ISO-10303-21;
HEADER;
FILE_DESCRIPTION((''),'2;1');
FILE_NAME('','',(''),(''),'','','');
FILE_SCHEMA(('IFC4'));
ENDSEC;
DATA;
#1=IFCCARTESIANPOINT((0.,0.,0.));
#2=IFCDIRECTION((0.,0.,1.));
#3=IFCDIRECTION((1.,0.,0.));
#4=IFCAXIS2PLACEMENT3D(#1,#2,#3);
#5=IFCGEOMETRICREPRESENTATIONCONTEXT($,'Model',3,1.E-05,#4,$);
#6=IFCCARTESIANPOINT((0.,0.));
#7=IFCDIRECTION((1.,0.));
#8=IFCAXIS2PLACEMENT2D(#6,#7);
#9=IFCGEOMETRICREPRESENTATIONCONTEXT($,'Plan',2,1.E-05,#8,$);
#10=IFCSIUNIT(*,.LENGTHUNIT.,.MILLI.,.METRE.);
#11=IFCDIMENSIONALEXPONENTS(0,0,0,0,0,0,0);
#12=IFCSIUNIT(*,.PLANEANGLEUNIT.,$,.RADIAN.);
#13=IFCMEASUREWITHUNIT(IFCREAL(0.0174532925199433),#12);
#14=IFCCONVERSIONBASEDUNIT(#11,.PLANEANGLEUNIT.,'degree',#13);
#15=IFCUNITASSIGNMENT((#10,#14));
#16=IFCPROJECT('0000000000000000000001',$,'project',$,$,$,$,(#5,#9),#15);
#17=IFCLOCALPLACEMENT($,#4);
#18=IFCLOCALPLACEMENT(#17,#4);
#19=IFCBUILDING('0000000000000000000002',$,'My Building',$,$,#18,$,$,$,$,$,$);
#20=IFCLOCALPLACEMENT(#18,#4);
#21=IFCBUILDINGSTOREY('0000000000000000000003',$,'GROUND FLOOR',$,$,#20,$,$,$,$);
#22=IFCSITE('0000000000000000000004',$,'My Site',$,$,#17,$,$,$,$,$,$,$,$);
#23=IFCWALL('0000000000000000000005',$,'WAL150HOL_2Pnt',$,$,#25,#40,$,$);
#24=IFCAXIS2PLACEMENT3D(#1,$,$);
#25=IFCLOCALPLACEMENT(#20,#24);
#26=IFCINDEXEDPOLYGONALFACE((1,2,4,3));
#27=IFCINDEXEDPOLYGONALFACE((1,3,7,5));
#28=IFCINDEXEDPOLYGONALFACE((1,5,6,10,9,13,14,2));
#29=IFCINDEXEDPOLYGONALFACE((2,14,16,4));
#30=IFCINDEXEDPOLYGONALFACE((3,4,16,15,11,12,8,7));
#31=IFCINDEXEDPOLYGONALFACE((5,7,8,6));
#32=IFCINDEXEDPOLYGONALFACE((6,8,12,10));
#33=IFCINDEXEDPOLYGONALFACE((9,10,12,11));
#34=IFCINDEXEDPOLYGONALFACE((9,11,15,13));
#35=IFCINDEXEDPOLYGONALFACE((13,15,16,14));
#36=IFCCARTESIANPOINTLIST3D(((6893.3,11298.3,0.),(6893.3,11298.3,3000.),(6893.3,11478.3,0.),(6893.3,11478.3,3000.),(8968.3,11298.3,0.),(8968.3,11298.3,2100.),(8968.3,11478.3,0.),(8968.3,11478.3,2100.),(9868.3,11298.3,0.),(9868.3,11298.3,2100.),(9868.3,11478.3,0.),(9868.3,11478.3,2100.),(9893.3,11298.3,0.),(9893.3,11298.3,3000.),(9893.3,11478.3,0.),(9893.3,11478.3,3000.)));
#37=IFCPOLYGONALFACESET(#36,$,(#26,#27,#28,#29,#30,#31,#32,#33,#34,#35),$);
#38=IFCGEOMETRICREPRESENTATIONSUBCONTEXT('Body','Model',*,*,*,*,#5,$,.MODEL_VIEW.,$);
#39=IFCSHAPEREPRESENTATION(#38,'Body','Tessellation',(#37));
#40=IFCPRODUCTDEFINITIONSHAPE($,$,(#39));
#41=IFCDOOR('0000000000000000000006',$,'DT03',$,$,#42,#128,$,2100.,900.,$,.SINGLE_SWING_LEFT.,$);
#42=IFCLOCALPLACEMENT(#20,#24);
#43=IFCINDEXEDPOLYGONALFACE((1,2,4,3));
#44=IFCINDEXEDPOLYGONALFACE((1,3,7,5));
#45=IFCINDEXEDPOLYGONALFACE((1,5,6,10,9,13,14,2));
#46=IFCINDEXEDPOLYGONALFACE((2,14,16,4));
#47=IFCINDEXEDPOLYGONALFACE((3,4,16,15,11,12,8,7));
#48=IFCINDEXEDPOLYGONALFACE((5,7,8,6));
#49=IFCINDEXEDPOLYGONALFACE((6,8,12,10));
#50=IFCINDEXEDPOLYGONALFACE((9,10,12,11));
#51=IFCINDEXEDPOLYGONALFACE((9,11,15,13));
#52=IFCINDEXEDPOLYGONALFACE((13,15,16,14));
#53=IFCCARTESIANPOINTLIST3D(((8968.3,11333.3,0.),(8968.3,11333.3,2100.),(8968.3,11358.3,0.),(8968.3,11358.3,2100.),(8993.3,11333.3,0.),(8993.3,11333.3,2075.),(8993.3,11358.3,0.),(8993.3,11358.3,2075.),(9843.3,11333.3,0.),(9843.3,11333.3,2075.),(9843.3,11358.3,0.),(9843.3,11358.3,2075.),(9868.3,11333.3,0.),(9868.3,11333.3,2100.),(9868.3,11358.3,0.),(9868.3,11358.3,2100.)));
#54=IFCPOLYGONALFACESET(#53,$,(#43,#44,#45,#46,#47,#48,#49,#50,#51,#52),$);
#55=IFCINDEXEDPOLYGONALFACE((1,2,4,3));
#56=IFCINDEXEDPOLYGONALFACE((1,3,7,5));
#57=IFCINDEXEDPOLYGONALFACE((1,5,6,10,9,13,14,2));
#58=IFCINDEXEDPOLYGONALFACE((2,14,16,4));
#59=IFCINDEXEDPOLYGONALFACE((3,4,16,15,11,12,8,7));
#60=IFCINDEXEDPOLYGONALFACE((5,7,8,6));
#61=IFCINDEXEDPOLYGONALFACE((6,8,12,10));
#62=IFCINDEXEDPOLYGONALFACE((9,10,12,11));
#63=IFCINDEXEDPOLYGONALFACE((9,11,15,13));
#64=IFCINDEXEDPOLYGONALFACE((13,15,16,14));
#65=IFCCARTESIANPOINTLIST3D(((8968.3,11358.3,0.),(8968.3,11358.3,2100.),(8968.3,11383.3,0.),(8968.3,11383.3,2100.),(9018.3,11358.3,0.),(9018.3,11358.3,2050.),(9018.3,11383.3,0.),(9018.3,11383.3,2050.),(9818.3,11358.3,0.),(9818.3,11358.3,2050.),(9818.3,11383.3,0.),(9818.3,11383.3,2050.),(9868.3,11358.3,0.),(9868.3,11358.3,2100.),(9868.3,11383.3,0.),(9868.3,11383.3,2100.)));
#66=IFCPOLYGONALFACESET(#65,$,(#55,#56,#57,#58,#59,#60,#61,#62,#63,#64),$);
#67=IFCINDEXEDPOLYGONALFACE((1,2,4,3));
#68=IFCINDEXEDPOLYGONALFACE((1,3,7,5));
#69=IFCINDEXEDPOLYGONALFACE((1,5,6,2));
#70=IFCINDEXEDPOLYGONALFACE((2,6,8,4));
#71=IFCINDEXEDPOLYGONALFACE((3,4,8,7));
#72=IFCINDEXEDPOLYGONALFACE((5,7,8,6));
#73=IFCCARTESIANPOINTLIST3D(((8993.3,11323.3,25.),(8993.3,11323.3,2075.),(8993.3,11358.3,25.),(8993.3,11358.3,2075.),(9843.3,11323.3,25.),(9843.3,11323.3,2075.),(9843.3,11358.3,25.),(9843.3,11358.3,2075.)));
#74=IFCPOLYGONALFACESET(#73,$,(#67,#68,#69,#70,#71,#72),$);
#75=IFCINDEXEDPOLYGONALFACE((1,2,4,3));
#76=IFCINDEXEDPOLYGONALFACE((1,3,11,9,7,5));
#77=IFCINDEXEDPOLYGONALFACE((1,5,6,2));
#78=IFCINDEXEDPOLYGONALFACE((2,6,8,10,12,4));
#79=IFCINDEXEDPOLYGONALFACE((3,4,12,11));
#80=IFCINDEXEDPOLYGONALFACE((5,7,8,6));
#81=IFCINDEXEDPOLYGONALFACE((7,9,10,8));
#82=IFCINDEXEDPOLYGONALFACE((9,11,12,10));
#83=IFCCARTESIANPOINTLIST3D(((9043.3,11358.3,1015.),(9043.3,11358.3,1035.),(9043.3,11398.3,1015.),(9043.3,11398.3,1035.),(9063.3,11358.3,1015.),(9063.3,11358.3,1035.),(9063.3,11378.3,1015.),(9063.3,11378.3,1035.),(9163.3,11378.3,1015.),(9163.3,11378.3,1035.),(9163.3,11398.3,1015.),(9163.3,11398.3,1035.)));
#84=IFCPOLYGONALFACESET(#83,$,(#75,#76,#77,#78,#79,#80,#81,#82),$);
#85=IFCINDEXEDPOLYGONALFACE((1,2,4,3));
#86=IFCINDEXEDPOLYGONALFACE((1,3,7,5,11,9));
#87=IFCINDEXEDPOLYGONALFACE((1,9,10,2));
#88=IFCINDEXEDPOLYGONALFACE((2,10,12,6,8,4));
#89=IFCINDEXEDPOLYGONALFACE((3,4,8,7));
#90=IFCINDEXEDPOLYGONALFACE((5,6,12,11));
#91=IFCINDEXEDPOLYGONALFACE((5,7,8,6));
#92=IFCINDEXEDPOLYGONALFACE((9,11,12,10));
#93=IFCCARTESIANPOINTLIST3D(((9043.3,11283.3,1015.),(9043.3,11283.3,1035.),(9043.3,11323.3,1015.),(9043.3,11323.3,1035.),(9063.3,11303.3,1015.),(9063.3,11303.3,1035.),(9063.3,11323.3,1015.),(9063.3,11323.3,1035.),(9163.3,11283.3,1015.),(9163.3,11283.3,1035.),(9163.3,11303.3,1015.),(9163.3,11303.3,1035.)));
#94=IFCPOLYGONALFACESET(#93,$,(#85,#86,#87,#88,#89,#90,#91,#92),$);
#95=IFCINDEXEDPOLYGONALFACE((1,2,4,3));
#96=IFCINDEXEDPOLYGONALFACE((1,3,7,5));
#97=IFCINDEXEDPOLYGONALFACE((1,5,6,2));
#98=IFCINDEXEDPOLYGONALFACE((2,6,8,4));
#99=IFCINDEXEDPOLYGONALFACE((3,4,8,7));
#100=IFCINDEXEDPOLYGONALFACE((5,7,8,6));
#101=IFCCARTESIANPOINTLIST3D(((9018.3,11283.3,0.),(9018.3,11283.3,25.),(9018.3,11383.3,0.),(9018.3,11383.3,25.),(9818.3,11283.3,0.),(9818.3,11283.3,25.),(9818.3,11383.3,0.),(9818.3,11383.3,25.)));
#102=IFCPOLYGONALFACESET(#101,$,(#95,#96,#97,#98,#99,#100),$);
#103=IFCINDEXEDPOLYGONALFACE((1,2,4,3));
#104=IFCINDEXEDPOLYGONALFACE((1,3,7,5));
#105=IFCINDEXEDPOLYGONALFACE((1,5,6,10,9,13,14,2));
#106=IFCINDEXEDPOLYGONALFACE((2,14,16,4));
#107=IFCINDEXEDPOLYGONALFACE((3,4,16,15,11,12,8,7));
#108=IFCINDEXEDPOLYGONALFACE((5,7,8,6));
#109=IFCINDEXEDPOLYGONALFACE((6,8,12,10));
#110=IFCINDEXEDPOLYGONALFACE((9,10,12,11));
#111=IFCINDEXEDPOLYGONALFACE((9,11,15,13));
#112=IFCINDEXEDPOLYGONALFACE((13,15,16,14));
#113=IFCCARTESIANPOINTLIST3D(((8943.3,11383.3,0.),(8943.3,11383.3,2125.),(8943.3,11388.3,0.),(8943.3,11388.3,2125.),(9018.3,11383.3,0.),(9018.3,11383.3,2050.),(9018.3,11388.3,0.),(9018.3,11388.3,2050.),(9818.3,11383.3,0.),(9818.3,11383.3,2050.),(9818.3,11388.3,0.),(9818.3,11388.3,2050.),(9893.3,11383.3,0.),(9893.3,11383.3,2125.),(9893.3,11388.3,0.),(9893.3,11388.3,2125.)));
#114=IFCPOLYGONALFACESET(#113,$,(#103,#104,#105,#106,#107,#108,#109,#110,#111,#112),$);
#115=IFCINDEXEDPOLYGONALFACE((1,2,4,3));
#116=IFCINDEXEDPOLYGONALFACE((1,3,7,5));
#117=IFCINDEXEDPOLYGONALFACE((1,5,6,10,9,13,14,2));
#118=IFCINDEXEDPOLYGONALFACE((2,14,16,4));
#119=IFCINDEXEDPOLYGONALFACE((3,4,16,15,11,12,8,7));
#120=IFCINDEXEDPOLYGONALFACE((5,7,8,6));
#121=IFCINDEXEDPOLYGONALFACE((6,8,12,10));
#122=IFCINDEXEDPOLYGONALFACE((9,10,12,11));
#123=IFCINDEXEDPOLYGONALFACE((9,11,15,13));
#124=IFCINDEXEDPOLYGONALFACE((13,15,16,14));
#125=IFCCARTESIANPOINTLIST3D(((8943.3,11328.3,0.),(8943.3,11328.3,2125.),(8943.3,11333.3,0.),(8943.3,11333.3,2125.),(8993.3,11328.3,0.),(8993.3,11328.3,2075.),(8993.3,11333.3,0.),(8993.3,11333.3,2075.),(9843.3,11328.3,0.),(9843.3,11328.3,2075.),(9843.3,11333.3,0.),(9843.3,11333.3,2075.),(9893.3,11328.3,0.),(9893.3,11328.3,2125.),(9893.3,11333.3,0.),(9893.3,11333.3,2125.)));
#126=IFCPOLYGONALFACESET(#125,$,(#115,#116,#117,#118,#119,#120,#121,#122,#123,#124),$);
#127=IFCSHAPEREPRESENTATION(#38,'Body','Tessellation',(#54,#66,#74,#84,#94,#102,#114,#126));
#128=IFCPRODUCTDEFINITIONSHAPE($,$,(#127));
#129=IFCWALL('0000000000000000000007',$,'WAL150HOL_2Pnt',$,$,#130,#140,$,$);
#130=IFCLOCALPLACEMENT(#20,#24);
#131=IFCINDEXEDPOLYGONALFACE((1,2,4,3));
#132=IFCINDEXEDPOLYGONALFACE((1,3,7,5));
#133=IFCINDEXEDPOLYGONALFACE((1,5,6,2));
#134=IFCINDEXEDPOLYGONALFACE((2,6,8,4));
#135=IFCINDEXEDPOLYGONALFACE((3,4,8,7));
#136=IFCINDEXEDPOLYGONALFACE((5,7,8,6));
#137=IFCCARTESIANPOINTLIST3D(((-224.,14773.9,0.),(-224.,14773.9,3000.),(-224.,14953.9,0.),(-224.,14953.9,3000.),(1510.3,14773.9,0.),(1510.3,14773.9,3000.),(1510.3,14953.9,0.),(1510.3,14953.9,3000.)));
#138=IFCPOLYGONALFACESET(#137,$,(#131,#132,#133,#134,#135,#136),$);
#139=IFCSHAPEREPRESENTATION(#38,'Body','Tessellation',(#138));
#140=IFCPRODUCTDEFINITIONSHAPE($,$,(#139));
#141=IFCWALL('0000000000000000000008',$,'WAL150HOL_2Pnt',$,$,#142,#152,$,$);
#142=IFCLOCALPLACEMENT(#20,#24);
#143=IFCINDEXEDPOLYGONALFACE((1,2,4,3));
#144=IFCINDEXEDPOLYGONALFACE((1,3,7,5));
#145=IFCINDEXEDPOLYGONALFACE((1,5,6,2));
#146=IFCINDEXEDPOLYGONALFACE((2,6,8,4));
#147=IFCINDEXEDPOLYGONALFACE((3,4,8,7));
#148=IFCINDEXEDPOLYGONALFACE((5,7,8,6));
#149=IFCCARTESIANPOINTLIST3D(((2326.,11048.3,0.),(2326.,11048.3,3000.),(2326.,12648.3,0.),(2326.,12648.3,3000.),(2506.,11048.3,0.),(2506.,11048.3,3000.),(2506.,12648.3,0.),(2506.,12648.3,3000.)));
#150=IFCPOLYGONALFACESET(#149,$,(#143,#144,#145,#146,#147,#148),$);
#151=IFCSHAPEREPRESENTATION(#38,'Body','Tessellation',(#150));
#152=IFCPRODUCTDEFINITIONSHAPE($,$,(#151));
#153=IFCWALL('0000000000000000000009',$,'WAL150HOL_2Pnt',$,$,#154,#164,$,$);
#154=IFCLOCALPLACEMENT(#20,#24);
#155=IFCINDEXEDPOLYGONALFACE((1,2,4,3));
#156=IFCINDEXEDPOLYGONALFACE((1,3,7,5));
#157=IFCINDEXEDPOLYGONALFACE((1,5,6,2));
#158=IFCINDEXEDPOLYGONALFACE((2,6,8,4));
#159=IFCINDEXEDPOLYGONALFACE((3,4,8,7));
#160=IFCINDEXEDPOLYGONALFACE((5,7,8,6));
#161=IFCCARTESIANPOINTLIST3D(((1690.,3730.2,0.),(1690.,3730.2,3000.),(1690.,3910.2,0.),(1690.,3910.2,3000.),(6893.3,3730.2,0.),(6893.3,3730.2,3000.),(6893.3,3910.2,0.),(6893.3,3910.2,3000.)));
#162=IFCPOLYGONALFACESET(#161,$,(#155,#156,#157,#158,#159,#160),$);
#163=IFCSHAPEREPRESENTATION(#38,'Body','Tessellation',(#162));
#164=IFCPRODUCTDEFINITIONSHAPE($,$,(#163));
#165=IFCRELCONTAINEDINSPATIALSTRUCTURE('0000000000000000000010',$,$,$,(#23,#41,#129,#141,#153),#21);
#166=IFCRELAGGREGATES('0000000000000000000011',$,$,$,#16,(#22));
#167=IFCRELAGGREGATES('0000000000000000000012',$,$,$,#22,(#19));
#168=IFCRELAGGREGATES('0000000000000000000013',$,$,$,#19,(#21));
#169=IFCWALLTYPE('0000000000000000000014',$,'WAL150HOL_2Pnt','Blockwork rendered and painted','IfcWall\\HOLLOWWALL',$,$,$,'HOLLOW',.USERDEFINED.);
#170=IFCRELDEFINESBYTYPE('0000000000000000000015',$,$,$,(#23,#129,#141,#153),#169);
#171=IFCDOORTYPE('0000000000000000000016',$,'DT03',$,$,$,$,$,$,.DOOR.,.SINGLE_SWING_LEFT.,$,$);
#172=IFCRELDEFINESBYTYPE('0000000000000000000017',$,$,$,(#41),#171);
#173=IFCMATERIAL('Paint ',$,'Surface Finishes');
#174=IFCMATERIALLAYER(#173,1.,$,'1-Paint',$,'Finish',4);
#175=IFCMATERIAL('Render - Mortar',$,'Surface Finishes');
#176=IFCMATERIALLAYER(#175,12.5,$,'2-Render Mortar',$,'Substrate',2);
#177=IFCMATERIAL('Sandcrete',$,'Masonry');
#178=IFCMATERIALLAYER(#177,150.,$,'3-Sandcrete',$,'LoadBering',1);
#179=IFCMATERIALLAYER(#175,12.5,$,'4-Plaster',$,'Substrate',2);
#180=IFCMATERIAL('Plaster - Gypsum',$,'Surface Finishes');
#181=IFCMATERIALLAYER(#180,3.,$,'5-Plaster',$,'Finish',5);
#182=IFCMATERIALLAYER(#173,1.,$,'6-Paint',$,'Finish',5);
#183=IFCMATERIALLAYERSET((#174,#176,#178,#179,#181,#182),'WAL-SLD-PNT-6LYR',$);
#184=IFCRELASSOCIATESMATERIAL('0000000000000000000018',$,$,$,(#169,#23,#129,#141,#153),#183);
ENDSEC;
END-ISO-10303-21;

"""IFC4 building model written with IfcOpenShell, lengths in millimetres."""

from ifc_helpers import new_model, entity, si_unit, converted_unit, frame, origin_with_axes, origin_2d_with_axis, place, context, subcontext, project, spatial, line, indexed_curve, outline, extrude, shape, source, transform, mapped, material, layer, layer_set, layer_usage, type_object, type_shapes, element, fill, save


model = new_model("IFC4")

# Units and contexts
model_context = context("Model", 3, precision=1e-05, world=origin_with_axes())
plan_context = context("Plan", 2, precision=1e-05, world=origin_2d_with_axis())
body_context_1 = subcontext(model_context, "Body", "Model", "MODEL_VIEW")
body_context_2 = subcontext(plan_context, "Body", "Plan", "PLAN_VIEW")
ifc_project = project(units=[si_unit("LENGTHUNIT", "METRE", prefix="MILLI"), converted_unit("PLANEANGLEUNIT", "degree", entity("IfcReal", 0.0174532925199433), si_unit("PLANEANGLEUNIT", "RADIAN"), dimensions=[0, 0, 0, 0, 0, 0, 0])], contexts=[model_context, plan_context])

# Site, building, storey
site_placement = place(None, origin_with_axes())
site = spatial("IfcSite", under=ifc_project, at=site_placement, Name="My Site")
building_placement = place(site_placement, origin_with_axes())
building = spatial("IfcBuilding", under=site, at=building_placement, Name="My Building")
storey_placement = place(building_placement, origin_with_axes())
storey = spatial("IfcBuildingStorey", under=building, at=storey_placement, Name="GROUND FLOOR")

# Shared definitions
ifc_material_1 = material(Name="Paint ", Category="Surface Finishes")
ifc_layer_1 = layer(ifc_material_1, 1.0, Name="1-Paint", Category="Finish", Priority=4)
ifc_material_2 = material(Name="Render - Mortar", Category="Surface Finishes")
ifc_layer_2 = layer(ifc_material_2, 12.5, Name="2-Render Mortar", Category="Substrate", Priority=2)
ifc_material_3 = material(Name="Sandcrete", Category="Masonry")
ifc_layer_3 = layer(ifc_material_3, 150.0, Name="3-Sandcrete", Category="LoadBering", Priority=1)
ifc_layer_4 = layer(ifc_material_2, 12.5, Name="4-Plaster", Category="Substrate", Priority=2)
ifc_material_4 = material(Name="Plaster - Gypsum", Category="Surface Finishes")
ifc_layer_5 = layer(ifc_material_4, 3.0, Name="5-Plaster", Category="Finish", Priority=5)
ifc_layer_6 = layer(ifc_material_1, 1.0, Name="6-Paint", Category="Finish", Priority=5)
ifc_layer_set_1 = layer_set([ifc_layer_1, ifc_layer_2, ifc_layer_3, ifc_layer_4, ifc_layer_5, ifc_layer_6], Name="WAL-SLD-PNT-6LYR")
wall_type_1 = type_object("IfcWallType", Name="WAL150HOL_2Pnt", Description="Blockwork rendered and painted", ApplicableOccurrence="IfcWall\\HOLLOWWALL", ElementType="HOLLOW", PredefinedType="USERDEFINED", material=ifc_layer_set_1)

# Shared definitions
shared_shape_1 = source(origin_with_axes(), body_context_1, "Body", "SweptSolid", [
    extrude(outline(indexed_curve([(0.0, 0.0), (900.0, 0.0), (900.0, 2100.0), (0.0, 2100.0)], segments=[line(1, 2, 3, 4, 1)])), frame((0.0, -100.0, 0.0), z_axis=(0.0, -1.0, 0.0), x_axis=(1.0, 0.0, 0.0)), (0.0, 0.0, -1.0), 380.0),
])
door_type_1 = type_object("IfcDoorType", Name="DT03", OperationType="SINGLE_SWING_LEFT", PredefinedType="DOOR")
shared_shape_2 = source(origin_with_axes(), body_context_1, "Body", "SweptSolid", [
    extrude(outline(indexed_curve([(0.0, 0.0), (0.0, 2100.0), (900.0, 2100.0), (900.0, 0.0), (875.0, 0.0), (875.0, 2075.0), (25.0, 2075.0), (25.0, 0.0)], segments=[line(1, 2, 3, 4, 5, 6, 7, 8, 1)])), frame((0.0, 25.0, 0.0), z_axis=(0.0, -1.0, 0.0), x_axis=(1.0, 0.0, 0.0)), (0.0, 0.0, -1.0), 25.0),
    extrude(outline(indexed_curve([(0.0, 0.0), (0.0, 2100.0), (900.0, 2100.0), (900.0, 0.0), (850.0, 0.0), (850.0, 2050.0), (50.0, 2050.0), (50.0, 0.0)], segments=[line(1, 2, 3, 4, 5, 6, 7, 8, 1)])), frame((0.0, 0.0, 0.0), z_axis=(0.0, -1.0, 0.0), x_axis=(1.0, 0.0, 0.0)), (0.0, 0.0, -1.0), 25.0),
    extrude(outline(indexed_curve([(0.0, 0.0), (850.0, 0.0), (850.0, 35.0), (0.0, 35.0)], segments=[line(1, 2, 3, 4, 1)])), frame((25.0, 25.0, 25.0), z_axis=(0.0, 0.0, 1.0), x_axis=(1.0, 0.0, 0.0)), (0.0, 0.0, 1.0), 2050.0),
    extrude(outline(indexed_curve([(0.0, 0.0), (0.0, -40.0), (-120.0, -40.0), (-120.0, -20.0), (-20.0, -20.0), (-20.0, 0.0)], segments=[line(1, 2, 3, 4, 5, 6, 1)])), frame((825.0, 25.0, 1015.0), z_axis=(0.0, 0.0, 1.0), x_axis=(1.0, 0.0, 0.0)), (0.0, 0.0, 1.0), 20.0),
    extrude(outline(indexed_curve([(0.0, 0.0), (0.0, 40.0), (-120.0, 40.0), (-120.0, 20.0), (-20.0, 20.0), (-20.0, 0.0)], segments=[line(1, 2, 3, 4, 5, 6, 1)])), frame((825.0, 60.0, 1015.0), z_axis=(0.0, 0.0, 1.0), x_axis=(1.0, 0.0, 0.0)), (0.0, 0.0, 1.0), 20.0),
    extrude(outline(indexed_curve([(0.0, 0.0), (800.0, 0.0), (800.0, 100.0), (0.0, 100.0)], segments=[line(1, 2, 3, 4, 1)])), frame((50.0, 0.0, 0.0), z_axis=(0.0, 0.0, 1.0), x_axis=(1.0, 0.0, 0.0)), (0.0, 0.0, 1.0), 25.0),
    extrude(outline(indexed_curve([(0.0, 0.0), (0.0, 2125.0), (950.0, 2125.0), (950.0, 0.0), (875.0, 0.0), (875.0, 2050.0), (75.0, 2050.0), (75.0, 0.0)], segments=[line(1, 2, 3, 4, 5, 6, 7, 8, 1)])), frame((-25.0, -5.0, 0.0), z_axis=(0.0, -1.0, 0.0), x_axis=(1.0, 0.0, 0.0)), (0.0, 0.0, -1.0), 5.0),
    extrude(outline(indexed_curve([(0.0, 0.0), (0.0, 2125.0), (950.0, 2125.0), (950.0, 0.0), (900.0, 0.0), (900.0, 2075.0), (50.0, 2075.0), (50.0, 0.0)], segments=[line(1, 2, 3, 4, 5, 6, 7, 8, 1)])), frame((-25.0, 50.0, 0.0), z_axis=(0.0, -1.0, 0.0), x_axis=(1.0, 0.0, 0.0)), (0.0, 0.0, -1.0), 5.0),
])
shared_shape_3 = source(origin_with_axes(), body_context_2, "Body", "Curve2D", [
    entity("IfcIndexedPolyCurve", entity("IfcCartesianPointList2D", [[0.0, 0.0], [0.0, 50.0], [25.0, 50.0], [25.0, 25.0], [50.0, 25.0], [50.0, 0.0]]), [entity("IfcLineIndex", [1, 2, 3, 4, 5, 6, 1])]),
    entity("IfcIndexedPolyCurve", entity("IfcCartesianPointList2D", [[900.0, 0.0], [900.0, 50.0], [875.0, 50.0], [875.0, 25.0], [850.0, 25.0], [850.0, 0.0]]), [entity("IfcLineIndex", [1, 2, 3, 4, 5, 6, 1])]),
    entity("IfcTrimmedCurve", entity("IfcEllipse", entity("IfcAxis2Placement2D", entity("IfcCartesianPoint", [60.0, 50.0]), entity("IfcDirection", [1.0, 0.0])), 815.0, 850.0), [entity("IfcCartesianPoint", [875.0, 50.0])], [entity("IfcCartesianPoint", [60.0, 900.0])], True, "CARTESIAN"),
    entity("IfcIndexedPolyCurve", entity("IfcCartesianPointList2D", [[25.0, 50.0], [60.0, 50.0], [60.0, 900.0], [25.0, 900.0]]), [entity("IfcLineIndex", [1, 2, 3, 4, 1])]),
])
type_shapes(door_type_1, [shared_shape_2, shared_shape_3])

# Wall, opening, door
ifc_layer_usage_1 = layer_usage(ifc_layer_set_1, "AXIS2", "POSITIVE", 0.0)
wall_1_placement = place(storey_placement, frame((6893.3, 11298.3, 0.0), z_axis=(0.0, 0.0, 1.0), x_axis=(1.0, -0.000002, 0.0)))
wall_1 = element("IfcWall", 1, at=wall_1_placement, inside=storey, type_object=wall_type_1, material=ifc_layer_usage_1, Name="WAL150HOL_2Pnt", context=body_context_1, shape_type="SweptSolid", body=[
    extrude(outline(indexed_curve([(0.0, 0.0), (0.0, 180.0), (3000.0, 180.0), (3000.0, 0.0), (0.0, 0.0)], self_intersect=False)), origin_with_axes(), (0.0, 0.0, 1.0), 3000.0),
])
opening_1_placement = place(wall_1_placement, frame((2075.0, 0.0, 0.0), z_axis=(0.0, 0.0, 1.0), x_axis=(1.0, 0.0, 0.0)))
opening_1 = element("IfcOpeningElement", 2, at=opening_1_placement, cuts=wall_1, PredefinedType="OPENING", context=body_context_1, shape_type="MappedRepresentation", body=[
    mapped(shared_shape_1, transform((0.0, 0.0, 0.0), x_axis=(1.0, 0.0, 0.0), y_axis=(0.0, 1.0, 0.0), z_axis=(0.0, 0.0, 1.0), scale=1.0)),
])
door_1_placement = place(opening_1_placement, frame((900.0, 85.0, 0.0), z_axis=(0.0, 0.0, 1.0), x_axis=(-1.0, 0.0, 0.0)))
door_1 = element("IfcDoor", 3, at=door_1_placement, inside=storey, type_object=door_type_1, Name="DT03", OperationType="SINGLE_SWING_LEFT", OverallHeight=2100.0, OverallWidth=900.0, shapes=[
    shape(body_context_1, "Body", "MappedRepresentation", [mapped(shared_shape_2, transform((0.0, 0.0, 0.0), x_axis=(1.0, 0.0, 0.0), y_axis=(0.0, 1.0, 0.0), z_axis=(0.0, 0.0, 1.0), scale=1.0))]),
    shape(body_context_2, "Body", "MappedRepresentation", [mapped(shared_shape_3, transform((0.0, 0.0, 0.0), x_axis=(1.0, 0.0, 0.0), y_axis=(0.0, 1.0, 0.0), z_axis=(0.0, 0.0, 1.0), scale=1.0))]),
])
fill(opening_1, door_1)

# Walls
ifc_layer_usage_2 = layer_usage(ifc_layer_set_1, "AXIS2", "POSITIVE", 0.0)
wall_2_placement = place(storey_placement, frame((1510.3, 14953.9, 0.0), z_axis=(0.0, 0.0, 1.0), x_axis=(-1.0, 0.0, 0.0)))
element("IfcWall", 4, at=wall_2_placement, inside=storey, type_object=wall_type_1, material=ifc_layer_usage_2, Name="WAL150HOL_2Pnt", context=body_context_1, shape_type="SweptSolid", body=[
    extrude(outline(indexed_curve([(0.0, 0.0), (0.0, 180.0), (1734.3, 180.0), (1734.3, 0.0), (0.0, 0.0)], self_intersect=False)), origin_with_axes(), (0.0, 0.0, 1.0), 3000.0),
])
ifc_layer_usage_3 = layer_usage(ifc_layer_set_1, "AXIS2", "POSITIVE", 0.0)
wall_3_placement = place(storey_placement, frame((2506.0, 11048.3, 0.0), z_axis=(0.0, 0.0, 1.0), x_axis=(0.0, 1.0, 0.0)))
element("IfcWall", 5, at=wall_3_placement, inside=storey, type_object=wall_type_1, material=ifc_layer_usage_3, Name="WAL150HOL_2Pnt", context=body_context_1, shape_type="SweptSolid", body=[
    extrude(outline(indexed_curve([(0.0, 0.0), (0.0, 180.0), (1600.0, 180.0), (1600.0, 0.0), (0.0, 0.0)], self_intersect=False)), origin_with_axes(), (0.0, 0.0, 1.0), 3000.0),
])
ifc_layer_usage_4 = layer_usage(ifc_layer_set_1, "AXIS2", "POSITIVE", 0.0)
wall_4_placement = place(storey_placement, frame((1690.0, 3730.2, 0.0), z_axis=(0.0, 0.0, 1.0), x_axis=(1.0, 0.0, 0.0)))
element("IfcWall", 6, at=wall_4_placement, inside=storey, type_object=wall_type_1, material=ifc_layer_usage_4, Name="WAL150HOL_2Pnt", context=body_context_1, shape_type="SweptSolid", body=[
    extrude(outline(indexed_curve([(0.0, 0.0), (0.0, 180.0), (5203.3, 180.0), (5203.3, 0.0), (0.0, 0.0)], self_intersect=False)), origin_with_axes(), (0.0, 0.0, 1.0), 3000.0),
])

save(model, "model.ifc")
